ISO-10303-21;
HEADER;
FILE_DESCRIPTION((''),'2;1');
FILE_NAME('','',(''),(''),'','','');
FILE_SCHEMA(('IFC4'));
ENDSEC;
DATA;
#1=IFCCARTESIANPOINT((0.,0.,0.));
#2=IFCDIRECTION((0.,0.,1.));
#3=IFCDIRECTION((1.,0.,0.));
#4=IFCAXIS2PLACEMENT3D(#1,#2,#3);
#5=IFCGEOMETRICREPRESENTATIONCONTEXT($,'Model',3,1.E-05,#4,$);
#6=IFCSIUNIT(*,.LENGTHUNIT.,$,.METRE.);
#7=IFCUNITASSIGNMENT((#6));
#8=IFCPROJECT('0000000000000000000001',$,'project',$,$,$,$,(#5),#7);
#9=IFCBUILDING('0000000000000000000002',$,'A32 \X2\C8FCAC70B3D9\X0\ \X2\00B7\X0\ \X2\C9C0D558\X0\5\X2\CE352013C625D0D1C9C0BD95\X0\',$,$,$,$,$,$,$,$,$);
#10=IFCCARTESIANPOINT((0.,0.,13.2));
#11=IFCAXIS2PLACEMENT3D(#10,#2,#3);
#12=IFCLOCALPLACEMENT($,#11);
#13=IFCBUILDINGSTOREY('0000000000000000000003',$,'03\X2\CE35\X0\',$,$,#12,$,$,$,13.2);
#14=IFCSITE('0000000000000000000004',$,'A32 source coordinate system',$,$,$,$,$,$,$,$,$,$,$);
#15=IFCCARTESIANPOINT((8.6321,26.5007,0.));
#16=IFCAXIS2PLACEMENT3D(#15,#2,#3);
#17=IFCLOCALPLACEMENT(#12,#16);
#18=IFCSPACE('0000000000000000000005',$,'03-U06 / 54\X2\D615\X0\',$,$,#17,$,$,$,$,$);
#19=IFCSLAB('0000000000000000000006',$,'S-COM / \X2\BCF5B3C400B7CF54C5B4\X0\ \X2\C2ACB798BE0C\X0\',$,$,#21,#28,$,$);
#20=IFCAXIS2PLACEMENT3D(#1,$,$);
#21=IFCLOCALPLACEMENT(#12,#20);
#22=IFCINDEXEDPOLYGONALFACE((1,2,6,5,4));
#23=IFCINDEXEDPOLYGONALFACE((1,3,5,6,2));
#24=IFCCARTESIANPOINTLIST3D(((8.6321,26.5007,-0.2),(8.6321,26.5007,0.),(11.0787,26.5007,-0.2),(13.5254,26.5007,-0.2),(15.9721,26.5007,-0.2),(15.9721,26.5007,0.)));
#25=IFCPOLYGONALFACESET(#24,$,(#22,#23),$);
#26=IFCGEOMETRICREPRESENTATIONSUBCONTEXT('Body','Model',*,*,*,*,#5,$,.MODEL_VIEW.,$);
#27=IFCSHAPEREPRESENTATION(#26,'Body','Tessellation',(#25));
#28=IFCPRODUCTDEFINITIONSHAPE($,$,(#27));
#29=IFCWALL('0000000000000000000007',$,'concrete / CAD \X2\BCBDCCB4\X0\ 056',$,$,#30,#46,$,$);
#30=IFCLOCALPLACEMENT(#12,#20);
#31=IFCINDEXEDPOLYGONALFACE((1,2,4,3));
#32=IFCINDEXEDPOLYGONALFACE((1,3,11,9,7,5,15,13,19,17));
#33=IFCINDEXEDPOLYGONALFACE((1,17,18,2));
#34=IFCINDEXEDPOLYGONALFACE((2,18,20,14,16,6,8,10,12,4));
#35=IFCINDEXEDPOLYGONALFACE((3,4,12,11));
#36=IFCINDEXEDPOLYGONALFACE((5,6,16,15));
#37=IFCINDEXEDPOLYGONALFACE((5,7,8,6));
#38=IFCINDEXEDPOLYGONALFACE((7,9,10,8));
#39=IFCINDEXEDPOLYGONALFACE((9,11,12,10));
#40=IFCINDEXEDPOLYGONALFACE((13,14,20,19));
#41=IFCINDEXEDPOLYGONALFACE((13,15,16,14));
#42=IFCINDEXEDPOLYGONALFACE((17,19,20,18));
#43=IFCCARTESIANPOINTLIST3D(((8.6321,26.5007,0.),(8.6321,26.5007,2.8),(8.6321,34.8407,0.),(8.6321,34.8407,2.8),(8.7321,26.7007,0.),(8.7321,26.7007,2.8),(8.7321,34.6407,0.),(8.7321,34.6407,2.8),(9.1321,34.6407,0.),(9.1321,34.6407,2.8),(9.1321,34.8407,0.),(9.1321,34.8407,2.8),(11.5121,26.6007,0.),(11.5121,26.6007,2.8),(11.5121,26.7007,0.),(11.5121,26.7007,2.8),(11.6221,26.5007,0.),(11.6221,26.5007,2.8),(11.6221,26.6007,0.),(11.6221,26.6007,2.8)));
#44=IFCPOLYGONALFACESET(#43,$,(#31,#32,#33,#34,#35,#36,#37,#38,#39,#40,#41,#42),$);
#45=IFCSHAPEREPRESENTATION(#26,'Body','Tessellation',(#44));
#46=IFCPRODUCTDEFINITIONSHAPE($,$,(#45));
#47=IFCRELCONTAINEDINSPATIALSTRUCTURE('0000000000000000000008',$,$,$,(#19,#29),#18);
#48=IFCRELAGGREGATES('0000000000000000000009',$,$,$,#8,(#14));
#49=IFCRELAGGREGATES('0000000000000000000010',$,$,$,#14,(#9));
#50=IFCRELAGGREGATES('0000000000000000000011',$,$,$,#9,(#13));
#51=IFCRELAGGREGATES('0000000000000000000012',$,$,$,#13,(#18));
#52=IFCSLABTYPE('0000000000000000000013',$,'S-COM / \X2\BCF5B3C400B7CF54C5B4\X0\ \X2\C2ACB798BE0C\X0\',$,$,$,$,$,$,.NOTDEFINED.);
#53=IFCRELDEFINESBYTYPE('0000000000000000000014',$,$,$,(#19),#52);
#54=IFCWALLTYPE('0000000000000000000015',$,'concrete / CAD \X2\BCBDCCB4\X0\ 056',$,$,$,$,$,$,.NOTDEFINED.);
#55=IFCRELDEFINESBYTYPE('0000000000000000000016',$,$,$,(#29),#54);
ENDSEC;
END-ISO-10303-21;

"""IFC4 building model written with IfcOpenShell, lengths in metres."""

from ifc_helpers import new_model, si_unit, frame, origin, origin_with_axes, place, context, subcontext, project, spatial, polyline, outline, extrude, source, transform, mapped, type_object, type_shapes, element, save


model = new_model("IFC4")

# Units and contexts
model_context = context("Model", 3, precision=1e-05, world=origin_with_axes())
body_context = subcontext(model_context, "Body", "Model", "MODEL_VIEW")
ifc_project = project(units=[si_unit("LENGTHUNIT", "METRE")], contexts=[model_context])

# Site, building, storey, space
site = spatial("IfcSite", under=ifc_project, Name="A32 source coordinate system")
building = spatial("IfcBuilding", under=site, Name="A32 주거동 · 지하5층–옥탑지붕")
storey_placement = place(None, frame((0.0, 0.0, 13.2), z_axis=(0.0, 0.0, 1.0), x_axis=(1.0, 0.0, 0.0)))
storey = spatial("IfcBuildingStorey", under=building, at=storey_placement, Name="03층", Elevation=13.2)
space_placement = place(storey_placement, frame((8.6321, 26.5007, 0.0), z_axis=(0.0, 0.0, 1.0), x_axis=(1.0, 0.0, 0.0)))
space = spatial("IfcSpace", under=storey, at=space_placement, Name="03-U06 / 54형")

# Slab
slab_type = type_object("IfcSlabType", Name="S-COM / 복도·코어 슬래브", PredefinedType="NOTDEFINED")
shared_shape_1 = source(origin(), body_context, "Body", "SweptSolid", [
    extrude(outline(polyline([(7.34, 0.0), (7.34, 0.0), (7.34, 0.0), (0.0, 0.0), (0.0, 0.0), (7.34, 0.0)])), frame((0.0, 0.0, -0.2)), (0.0, 0.0, 1.0), 0.2),
])
type_shapes(slab_type, [shared_shape_1])
slab_placement = place(space_placement, origin_with_axes())
element("IfcSlab", 1, at=slab_placement, inside=space, type_object=slab_type, Name="S-COM / 복도·코어 슬래브", context=body_context, shape_type="MappedRepresentation", body=[
    mapped(shared_shape_1, transform((0.0, 0.0, 0.0), scale=1.0)),
])

# Wall
wall_type_1 = type_object("IfcWallType", Name="concrete / CAD 벽체 056", PredefinedType="NOTDEFINED")
shared_shape_2 = source(origin(), body_context, "Body", "SweptSolid", [
    extrude(outline(polyline([(0.1, 8.14), (0.1, 0.2), (2.88, 0.2), (2.88, 0.1), (2.99, 0.1), (2.99, 0.0), (0.0, 0.0), (0.0, 8.34), (-0.35, 8.34), (-0.35, 8.34), (0.5, 8.34), (0.5, 8.14), (0.1, 8.14)])), origin(), (0.0, 0.0, 1.0), 2.8),
])
type_shapes(wall_type_1, [shared_shape_2])
wall_1_placement = place(space_placement, origin_with_axes())
element("IfcWall", 2, at=wall_1_placement, inside=space, type_object=wall_type_1, Name="concrete / CAD 벽체 056", context=body_context, shape_type="MappedRepresentation", body=[
    mapped(shared_shape_2, transform((0.0, 0.0, 0.0), scale=1.0)),
])

save(model, "model.ifc")
